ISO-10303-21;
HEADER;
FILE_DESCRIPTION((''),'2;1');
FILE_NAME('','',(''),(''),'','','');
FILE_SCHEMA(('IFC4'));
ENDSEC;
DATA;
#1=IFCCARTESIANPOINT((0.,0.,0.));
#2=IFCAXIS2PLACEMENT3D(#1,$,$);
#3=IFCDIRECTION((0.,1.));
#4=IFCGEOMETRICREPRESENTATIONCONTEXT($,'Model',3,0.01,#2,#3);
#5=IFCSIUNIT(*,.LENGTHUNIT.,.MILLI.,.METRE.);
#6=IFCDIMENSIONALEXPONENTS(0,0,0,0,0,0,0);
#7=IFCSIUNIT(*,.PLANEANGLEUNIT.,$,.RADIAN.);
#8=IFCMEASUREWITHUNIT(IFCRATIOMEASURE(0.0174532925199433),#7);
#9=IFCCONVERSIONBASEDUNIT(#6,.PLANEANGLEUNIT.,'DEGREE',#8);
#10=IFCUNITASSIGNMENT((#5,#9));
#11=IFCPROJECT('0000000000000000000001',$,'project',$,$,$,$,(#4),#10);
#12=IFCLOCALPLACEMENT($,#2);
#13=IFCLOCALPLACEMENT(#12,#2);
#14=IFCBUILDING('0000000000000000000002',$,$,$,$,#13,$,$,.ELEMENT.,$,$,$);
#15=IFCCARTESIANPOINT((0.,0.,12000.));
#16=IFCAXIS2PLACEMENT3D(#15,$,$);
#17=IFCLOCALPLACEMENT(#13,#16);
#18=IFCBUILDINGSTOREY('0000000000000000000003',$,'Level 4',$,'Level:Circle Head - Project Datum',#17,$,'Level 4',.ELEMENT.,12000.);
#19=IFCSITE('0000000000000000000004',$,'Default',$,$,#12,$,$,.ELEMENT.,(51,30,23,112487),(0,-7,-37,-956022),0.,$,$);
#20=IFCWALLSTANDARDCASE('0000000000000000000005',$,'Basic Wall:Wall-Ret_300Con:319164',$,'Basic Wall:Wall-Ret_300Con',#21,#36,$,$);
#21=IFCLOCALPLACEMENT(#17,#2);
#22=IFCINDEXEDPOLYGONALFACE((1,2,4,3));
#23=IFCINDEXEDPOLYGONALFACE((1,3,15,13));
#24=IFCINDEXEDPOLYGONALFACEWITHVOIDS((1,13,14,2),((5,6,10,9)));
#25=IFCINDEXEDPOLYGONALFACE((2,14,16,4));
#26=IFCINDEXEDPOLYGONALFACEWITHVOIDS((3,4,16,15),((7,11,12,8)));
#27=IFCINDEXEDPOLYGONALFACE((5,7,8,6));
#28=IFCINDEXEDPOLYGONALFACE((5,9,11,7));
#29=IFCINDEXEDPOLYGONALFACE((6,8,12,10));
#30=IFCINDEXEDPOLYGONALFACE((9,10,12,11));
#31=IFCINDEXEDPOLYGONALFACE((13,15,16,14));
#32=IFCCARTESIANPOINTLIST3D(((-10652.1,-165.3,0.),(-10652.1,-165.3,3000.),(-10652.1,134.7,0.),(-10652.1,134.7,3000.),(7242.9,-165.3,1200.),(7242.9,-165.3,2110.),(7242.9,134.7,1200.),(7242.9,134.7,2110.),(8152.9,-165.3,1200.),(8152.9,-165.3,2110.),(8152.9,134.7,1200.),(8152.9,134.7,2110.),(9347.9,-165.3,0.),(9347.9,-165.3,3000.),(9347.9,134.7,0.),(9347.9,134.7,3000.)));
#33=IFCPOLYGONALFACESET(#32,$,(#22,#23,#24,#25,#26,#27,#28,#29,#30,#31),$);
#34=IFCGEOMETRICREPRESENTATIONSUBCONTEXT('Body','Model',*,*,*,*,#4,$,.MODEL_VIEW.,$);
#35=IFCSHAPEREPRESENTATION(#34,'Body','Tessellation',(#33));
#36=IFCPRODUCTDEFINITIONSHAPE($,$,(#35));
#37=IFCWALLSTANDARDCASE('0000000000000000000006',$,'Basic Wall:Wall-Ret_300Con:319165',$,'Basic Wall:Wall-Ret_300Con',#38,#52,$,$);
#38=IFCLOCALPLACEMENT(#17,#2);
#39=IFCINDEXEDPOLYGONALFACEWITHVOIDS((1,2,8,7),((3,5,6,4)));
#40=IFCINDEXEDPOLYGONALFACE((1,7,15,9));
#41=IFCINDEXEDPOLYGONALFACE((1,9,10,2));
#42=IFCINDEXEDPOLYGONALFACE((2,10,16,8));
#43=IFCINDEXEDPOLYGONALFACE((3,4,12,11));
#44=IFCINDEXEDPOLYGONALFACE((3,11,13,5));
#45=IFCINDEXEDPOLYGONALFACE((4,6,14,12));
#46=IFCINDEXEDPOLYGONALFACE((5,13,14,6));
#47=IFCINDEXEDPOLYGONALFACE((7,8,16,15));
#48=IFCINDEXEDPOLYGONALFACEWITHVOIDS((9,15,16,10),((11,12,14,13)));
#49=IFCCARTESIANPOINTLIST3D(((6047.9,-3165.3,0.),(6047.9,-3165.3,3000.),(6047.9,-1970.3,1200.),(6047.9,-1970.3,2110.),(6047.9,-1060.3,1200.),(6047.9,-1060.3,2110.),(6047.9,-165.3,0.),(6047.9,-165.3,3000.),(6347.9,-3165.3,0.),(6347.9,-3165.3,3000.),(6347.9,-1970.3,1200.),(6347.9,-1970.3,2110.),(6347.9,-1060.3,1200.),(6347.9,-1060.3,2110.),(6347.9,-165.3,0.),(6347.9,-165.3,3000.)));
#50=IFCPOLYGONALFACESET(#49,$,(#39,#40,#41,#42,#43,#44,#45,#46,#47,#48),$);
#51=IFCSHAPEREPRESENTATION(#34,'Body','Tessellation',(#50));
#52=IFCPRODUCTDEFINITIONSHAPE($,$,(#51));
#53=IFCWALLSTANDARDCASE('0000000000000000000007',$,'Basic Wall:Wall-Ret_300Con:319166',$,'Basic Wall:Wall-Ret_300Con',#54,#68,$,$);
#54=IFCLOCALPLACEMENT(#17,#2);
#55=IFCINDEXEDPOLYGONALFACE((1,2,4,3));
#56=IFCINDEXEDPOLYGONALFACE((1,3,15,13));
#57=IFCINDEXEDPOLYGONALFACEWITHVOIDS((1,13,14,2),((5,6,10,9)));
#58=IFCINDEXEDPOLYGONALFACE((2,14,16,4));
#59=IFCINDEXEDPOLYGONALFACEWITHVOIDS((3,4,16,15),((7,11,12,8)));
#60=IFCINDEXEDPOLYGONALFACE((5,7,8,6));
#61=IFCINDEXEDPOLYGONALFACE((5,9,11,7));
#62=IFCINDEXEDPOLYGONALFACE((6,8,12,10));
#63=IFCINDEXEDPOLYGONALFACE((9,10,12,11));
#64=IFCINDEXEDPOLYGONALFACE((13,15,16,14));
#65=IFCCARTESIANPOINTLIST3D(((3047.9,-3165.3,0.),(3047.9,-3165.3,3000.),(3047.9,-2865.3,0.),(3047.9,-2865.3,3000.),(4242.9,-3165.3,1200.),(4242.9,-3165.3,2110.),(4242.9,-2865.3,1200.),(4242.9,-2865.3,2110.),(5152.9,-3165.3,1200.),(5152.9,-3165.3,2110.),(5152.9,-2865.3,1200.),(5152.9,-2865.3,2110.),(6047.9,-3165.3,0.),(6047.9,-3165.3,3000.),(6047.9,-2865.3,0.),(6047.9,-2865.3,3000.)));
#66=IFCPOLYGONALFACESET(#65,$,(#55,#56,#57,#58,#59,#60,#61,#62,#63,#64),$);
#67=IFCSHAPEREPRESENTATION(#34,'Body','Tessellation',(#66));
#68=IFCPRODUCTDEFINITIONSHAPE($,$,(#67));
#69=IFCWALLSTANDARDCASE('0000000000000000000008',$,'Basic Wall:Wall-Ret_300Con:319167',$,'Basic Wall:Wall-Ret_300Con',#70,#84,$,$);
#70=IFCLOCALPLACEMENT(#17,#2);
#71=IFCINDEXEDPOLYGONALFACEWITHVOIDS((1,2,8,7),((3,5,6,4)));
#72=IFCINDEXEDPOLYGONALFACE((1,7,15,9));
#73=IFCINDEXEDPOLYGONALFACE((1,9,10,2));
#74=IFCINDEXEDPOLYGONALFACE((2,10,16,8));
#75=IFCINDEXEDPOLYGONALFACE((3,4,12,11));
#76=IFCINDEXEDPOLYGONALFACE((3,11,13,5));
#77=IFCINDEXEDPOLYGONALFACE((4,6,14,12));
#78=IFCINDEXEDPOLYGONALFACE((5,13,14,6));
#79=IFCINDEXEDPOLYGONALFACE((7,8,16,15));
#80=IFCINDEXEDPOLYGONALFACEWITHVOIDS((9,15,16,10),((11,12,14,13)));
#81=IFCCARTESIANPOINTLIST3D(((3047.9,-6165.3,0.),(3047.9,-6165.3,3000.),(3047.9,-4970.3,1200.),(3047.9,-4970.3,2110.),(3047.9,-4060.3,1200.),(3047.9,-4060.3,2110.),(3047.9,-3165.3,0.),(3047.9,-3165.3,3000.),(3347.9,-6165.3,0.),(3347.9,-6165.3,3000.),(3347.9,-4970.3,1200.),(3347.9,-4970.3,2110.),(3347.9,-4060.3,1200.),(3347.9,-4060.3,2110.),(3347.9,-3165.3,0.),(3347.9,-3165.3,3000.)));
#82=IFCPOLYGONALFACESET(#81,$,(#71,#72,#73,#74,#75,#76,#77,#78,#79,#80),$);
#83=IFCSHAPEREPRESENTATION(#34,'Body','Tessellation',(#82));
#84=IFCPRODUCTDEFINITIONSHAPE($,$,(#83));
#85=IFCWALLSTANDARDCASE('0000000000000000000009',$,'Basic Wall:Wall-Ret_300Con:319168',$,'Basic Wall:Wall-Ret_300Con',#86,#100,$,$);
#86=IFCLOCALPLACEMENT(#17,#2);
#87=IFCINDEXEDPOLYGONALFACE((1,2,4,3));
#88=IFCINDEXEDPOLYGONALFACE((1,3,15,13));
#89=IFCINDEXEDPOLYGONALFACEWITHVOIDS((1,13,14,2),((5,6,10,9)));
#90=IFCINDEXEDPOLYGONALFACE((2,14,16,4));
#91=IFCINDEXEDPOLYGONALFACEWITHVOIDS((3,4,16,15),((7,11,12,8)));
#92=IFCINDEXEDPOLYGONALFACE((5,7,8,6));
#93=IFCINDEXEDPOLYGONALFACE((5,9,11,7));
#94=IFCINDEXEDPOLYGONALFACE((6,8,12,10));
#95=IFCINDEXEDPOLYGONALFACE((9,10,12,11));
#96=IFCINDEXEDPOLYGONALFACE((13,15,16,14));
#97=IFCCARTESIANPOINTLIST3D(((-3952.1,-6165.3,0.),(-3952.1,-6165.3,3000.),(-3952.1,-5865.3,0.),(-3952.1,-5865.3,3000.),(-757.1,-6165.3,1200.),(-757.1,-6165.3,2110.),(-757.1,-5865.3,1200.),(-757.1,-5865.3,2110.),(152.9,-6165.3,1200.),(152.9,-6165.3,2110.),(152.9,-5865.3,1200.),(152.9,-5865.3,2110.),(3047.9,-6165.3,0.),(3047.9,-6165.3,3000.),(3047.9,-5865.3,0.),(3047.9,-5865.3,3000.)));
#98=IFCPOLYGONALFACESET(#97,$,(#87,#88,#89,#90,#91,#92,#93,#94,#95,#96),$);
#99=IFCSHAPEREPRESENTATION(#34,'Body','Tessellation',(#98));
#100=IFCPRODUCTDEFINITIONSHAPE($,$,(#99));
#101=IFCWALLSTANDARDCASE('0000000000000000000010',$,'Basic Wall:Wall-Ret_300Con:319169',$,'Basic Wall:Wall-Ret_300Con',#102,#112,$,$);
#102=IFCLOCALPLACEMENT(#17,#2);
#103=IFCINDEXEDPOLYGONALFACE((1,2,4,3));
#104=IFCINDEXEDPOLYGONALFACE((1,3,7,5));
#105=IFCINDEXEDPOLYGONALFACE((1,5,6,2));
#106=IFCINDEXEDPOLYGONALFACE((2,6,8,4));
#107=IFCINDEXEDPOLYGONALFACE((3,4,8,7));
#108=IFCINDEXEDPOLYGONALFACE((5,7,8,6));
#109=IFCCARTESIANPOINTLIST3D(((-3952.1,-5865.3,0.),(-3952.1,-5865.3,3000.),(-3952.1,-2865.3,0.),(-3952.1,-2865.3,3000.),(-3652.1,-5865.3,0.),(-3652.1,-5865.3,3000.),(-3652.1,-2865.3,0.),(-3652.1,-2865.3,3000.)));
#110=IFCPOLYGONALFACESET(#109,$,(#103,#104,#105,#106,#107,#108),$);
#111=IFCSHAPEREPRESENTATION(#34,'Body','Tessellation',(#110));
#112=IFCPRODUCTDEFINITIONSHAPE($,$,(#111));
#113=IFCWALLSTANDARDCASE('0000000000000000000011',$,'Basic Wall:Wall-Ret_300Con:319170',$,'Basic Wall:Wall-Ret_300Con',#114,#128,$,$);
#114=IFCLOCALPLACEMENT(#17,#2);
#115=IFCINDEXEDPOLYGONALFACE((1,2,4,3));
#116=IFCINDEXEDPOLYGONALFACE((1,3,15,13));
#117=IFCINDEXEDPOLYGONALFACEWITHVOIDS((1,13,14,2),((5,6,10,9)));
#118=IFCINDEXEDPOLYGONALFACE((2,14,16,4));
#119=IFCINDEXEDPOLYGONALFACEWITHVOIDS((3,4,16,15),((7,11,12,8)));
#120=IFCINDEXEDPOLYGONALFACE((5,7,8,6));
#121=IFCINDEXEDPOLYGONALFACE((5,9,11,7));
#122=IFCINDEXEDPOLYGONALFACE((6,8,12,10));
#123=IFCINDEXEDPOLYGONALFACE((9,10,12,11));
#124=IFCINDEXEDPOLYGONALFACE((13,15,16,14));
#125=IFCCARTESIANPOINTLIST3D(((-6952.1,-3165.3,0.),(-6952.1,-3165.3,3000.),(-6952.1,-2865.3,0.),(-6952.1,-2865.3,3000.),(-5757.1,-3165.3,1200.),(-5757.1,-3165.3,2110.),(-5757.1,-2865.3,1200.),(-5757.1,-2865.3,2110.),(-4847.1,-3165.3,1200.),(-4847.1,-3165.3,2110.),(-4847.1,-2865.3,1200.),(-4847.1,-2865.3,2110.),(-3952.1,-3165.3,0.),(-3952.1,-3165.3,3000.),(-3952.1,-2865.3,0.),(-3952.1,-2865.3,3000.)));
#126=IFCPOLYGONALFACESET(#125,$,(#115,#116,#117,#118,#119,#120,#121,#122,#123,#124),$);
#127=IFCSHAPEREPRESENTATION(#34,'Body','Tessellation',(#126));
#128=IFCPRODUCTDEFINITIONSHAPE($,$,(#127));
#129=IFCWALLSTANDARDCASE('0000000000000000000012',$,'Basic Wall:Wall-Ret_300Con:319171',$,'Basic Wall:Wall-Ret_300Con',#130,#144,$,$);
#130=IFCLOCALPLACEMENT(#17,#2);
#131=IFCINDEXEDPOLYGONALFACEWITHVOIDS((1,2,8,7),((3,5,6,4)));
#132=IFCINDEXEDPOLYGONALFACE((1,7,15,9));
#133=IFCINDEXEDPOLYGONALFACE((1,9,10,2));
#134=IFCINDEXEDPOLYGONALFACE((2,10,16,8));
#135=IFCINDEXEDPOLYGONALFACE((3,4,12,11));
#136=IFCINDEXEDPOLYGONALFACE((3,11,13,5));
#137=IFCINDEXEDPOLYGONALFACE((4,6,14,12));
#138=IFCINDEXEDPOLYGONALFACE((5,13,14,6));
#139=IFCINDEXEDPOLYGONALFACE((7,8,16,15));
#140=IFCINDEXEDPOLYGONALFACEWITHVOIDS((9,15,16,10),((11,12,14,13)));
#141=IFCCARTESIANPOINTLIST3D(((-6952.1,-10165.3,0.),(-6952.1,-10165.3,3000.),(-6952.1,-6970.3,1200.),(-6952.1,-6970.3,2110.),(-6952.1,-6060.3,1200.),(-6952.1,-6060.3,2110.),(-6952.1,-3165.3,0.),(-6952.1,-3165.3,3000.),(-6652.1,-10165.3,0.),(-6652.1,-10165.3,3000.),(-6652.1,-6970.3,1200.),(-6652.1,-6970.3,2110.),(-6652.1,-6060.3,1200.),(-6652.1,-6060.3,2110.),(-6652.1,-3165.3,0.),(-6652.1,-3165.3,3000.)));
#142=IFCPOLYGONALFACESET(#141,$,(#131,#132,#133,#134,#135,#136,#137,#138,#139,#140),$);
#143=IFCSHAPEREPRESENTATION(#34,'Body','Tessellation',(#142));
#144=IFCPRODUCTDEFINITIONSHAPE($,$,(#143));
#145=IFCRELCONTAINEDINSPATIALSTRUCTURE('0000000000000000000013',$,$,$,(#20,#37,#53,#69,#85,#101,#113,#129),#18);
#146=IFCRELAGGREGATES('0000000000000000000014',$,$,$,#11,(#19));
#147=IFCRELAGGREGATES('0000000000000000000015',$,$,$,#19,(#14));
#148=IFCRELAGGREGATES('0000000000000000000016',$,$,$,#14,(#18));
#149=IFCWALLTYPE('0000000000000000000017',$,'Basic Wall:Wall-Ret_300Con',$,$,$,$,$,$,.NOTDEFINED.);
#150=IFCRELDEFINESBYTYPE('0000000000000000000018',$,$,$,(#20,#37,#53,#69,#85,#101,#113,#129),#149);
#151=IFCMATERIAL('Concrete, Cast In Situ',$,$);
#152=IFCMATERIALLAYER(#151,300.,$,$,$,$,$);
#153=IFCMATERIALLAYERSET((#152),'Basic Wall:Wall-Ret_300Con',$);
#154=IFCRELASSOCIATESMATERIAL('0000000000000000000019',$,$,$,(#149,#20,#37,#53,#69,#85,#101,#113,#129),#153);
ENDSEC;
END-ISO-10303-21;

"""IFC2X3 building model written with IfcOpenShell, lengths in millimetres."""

from ifc_helpers import new_model, entity, si_unit, converted_unit, direction, frame, frame_2d, origin, place, context, subcontext, project, spatial, rectangle, extrude, material, layer, layer_set, layer_usage, type_object, element, save


model = new_model("IFC2X3")

# Units and contexts
model_context = context("Model", 3, precision=0.01, world=origin(), true_north=direction((0.0, 1.0)))
body_context = subcontext(model_context, "Body", "Model", "MODEL_VIEW")
ifc_project = project(units=[si_unit("LENGTHUNIT", "METRE", prefix="MILLI"), converted_unit("PLANEANGLEUNIT", "DEGREE", entity("IfcRatioMeasure", 0.0174532925199433), si_unit("PLANEANGLEUNIT", "RADIAN"), dimensions=[0, 0, 0, 0, 0, 0, 0])], contexts=[model_context])

# Site, building, storey
site_placement = place(None, origin())
site = spatial("IfcSite", under=ifc_project, at=site_placement, Name="Default", CompositionType="ELEMENT", RefLatitude=(51, 30, 23, 112487), RefLongitude=(0, -7, -37, -956022), RefElevation=0.0)
building_placement = place(site_placement, origin())
building = spatial("IfcBuilding", under=site, at=building_placement, CompositionType="ELEMENT")
storey_placement = place(building_placement, frame((0.0, 0.0, 12000.0)))
storey = spatial("IfcBuildingStorey", under=building, at=storey_placement, Name="Level 4", ObjectType="Level:Circle Head - Project Datum", LongName="Level 4", CompositionType="ELEMENT", Elevation=12000.0)

# Walls, openings
ifc_material_1 = material(Name="Concrete, Cast In Situ")
ifc_layer_1 = layer(ifc_material_1, 300.0)
ifc_layer_set_1 = layer_set([ifc_layer_1], Name="Basic Wall:Wall-Ret_300Con")
ifc_layer_usage_1 = layer_usage(ifc_layer_set_1, "AXIS2", "NEGATIVE", 150.0)
wall_type = type_object("IfcWallType", Name="Basic Wall:Wall-Ret_300Con", PredefinedType="NOTDEFINED", material=ifc_layer_set_1)
wall_1_placement = place(storey_placement, frame((9347.9, -15.3, 0.0), z_axis=(0.0, 0.0, 1.0), x_axis=(-1.0, 0.0, 0.0)))
wall_1 = element("IfcWallStandardCase", 1, at=wall_1_placement, inside=storey, type_object=wall_type, material=ifc_layer_usage_1, Name="Basic Wall:Wall-Ret_300Con:319164", ObjectType="Basic Wall:Wall-Ret_300Con", context=body_context, shape_type="SweptSolid", body=[
    extrude(rectangle(XDim=20000.0, YDim=300.0, at=frame_2d((10000.0, 0.0), x_axis=(-1.0, 0.0))), origin(), (0.0, 0.0, 1.0), 3000.0),
])
opening_1_placement = place(wall_1_placement, frame((1195.0, -150.0, 1200.0)))
element("IfcOpeningElement", 2, at=opening_1_placement, cuts=wall_1, ObjectType="Opening", context=body_context, shape_type="SweptSolid", body=[
    extrude(rectangle(XDim=910.0, YDim=910.0, at=frame_2d((455.0, 455.0), x_axis=(-1.0, 0.0))), frame((0.0, 0.0, 0.0), z_axis=(0.0, 1.0, 0.0), x_axis=(0.0, 0.0, 1.0)), (0.0, 0.0, 1.0), 300.0),
])
ifc_layer_usage_2 = layer_usage(ifc_layer_set_1, "AXIS2", "NEGATIVE", 150.0)
wall_2_placement = place(storey_placement, frame((6197.9, -165.3, 0.0), z_axis=(0.0, 0.0, 1.0), x_axis=(0.0, -1.0, 0.0)))
wall_2 = element("IfcWallStandardCase", 3, at=wall_2_placement, inside=storey, type_object=wall_type, material=ifc_layer_usage_2, Name="Basic Wall:Wall-Ret_300Con:319165", ObjectType="Basic Wall:Wall-Ret_300Con", context=body_context, shape_type="SweptSolid", body=[
    extrude(rectangle(XDim=3000.0, YDim=300.0, at=frame_2d((1500.0, 0.0), x_axis=(-1.0, 0.0))), origin(), (0.0, 0.0, 1.0), 3000.0),
])
opening_2_placement = place(wall_2_placement, frame((895.0, -150.0, 1200.0)))
element("IfcOpeningElement", 4, at=opening_2_placement, cuts=wall_2, ObjectType="Opening", context=body_context, shape_type="SweptSolid", body=[
    extrude(rectangle(XDim=910.0, YDim=910.0, at=frame_2d((455.0, 455.0), x_axis=(-1.0, 0.0))), frame((0.0, 0.0, 0.0), z_axis=(0.0, 1.0, 0.0), x_axis=(0.0, 0.0, 1.0)), (0.0, 0.0, 1.0), 300.0),
])
ifc_layer_usage_3 = layer_usage(ifc_layer_set_1, "AXIS2", "NEGATIVE", 150.0)
wall_3_placement = place(storey_placement, frame((6047.9, -3015.3, 0.0), z_axis=(0.0, 0.0, 1.0), x_axis=(-1.0, 0.0, 0.0)))
wall_3 = element("IfcWallStandardCase", 5, at=wall_3_placement, inside=storey, type_object=wall_type, material=ifc_layer_usage_3, Name="Basic Wall:Wall-Ret_300Con:319166", ObjectType="Basic Wall:Wall-Ret_300Con", context=body_context, shape_type="SweptSolid", body=[
    extrude(rectangle(XDim=3000.0, YDim=300.0, at=frame_2d((1500.0, 0.0), x_axis=(-1.0, 0.0))), origin(), (0.0, 0.0, 1.0), 3000.0),
])
opening_3_placement = place(wall_3_placement, frame((895.0, -150.0, 1200.0)))
element("IfcOpeningElement", 6, at=opening_3_placement, cuts=wall_3, ObjectType="Opening", context=body_context, shape_type="SweptSolid", body=[
    extrude(rectangle(XDim=910.0, YDim=910.0, at=frame_2d((455.0, 455.0), x_axis=(-1.0, 0.0))), frame((0.0, 0.0, 0.0), z_axis=(0.0, 1.0, 0.0), x_axis=(0.0, 0.0, 1.0)), (0.0, 0.0, 1.0), 300.0),
])
ifc_layer_usage_4 = layer_usage(ifc_layer_set_1, "AXIS2", "NEGATIVE", 150.0)
wall_4_placement = place(storey_placement, frame((3197.9, -3165.3, 0.0), z_axis=(0.0, 0.0, 1.0), x_axis=(0.0, -1.0, 0.0)))
wall_4 = element("IfcWallStandardCase", 7, at=wall_4_placement, inside=storey, type_object=wall_type, material=ifc_layer_usage_4, Name="Basic Wall:Wall-Ret_300Con:319167", ObjectType="Basic Wall:Wall-Ret_300Con", context=body_context, shape_type="SweptSolid", body=[
    extrude(rectangle(XDim=3000.0, YDim=300.0, at=frame_2d((1500.0, 0.0), x_axis=(-1.0, 0.0))), origin(), (0.0, 0.0, 1.0), 3000.0),
])
opening_4_placement = place(wall_4_placement, frame((895.0, -150.0, 1200.0)))
element("IfcOpeningElement", 8, at=opening_4_placement, cuts=wall_4, ObjectType="Opening", context=body_context, shape_type="SweptSolid", body=[
    extrude(rectangle(XDim=910.0, YDim=910.0, at=frame_2d((455.0, 455.0), x_axis=(-1.0, 0.0))), frame((0.0, 0.0, 0.0), z_axis=(0.0, 1.0, 0.0), x_axis=(0.0, 0.0, 1.0)), (0.0, 0.0, 1.0), 300.0),
])
ifc_layer_usage_5 = layer_usage(ifc_layer_set_1, "AXIS2", "NEGATIVE", 150.0)
wall_5_placement = place(storey_placement, frame((3047.9, -6015.3, 0.0), z_axis=(0.0, 0.0, 1.0), x_axis=(-1.0, 0.0, 0.0)))
wall_5 = element("IfcWallStandardCase", 9, at=wall_5_placement, inside=storey, type_object=wall_type, material=ifc_layer_usage_5, Name="Basic Wall:Wall-Ret_300Con:319168", ObjectType="Basic Wall:Wall-Ret_300Con", context=body_context, shape_type="SweptSolid", body=[
    extrude(rectangle(XDim=7000.0, YDim=300.0, at=frame_2d((3500.0, 0.0), x_axis=(-1.0, 0.0))), origin(), (0.0, 0.0, 1.0), 3000.0),
])
opening_5_placement = place(wall_5_placement, frame((2895.0, -150.0, 1200.0)))
element("IfcOpeningElement", 10, at=opening_5_placement, cuts=wall_5, ObjectType="Opening", context=body_context, shape_type="SweptSolid", body=[
    extrude(rectangle(XDim=910.0, YDim=910.0, at=frame_2d((455.0, 455.0), x_axis=(-1.0, 0.0))), frame((0.0, 0.0, 0.0), z_axis=(0.0, 1.0, 0.0), x_axis=(0.0, 0.0, 1.0)), (0.0, 0.0, 1.0), 300.0),
])

# Wall
ifc_layer_usage_6 = layer_usage(ifc_layer_set_1, "AXIS2", "NEGATIVE", 150.0)
wall_6_placement = place(storey_placement, frame((-3802.1, -5865.3, 0.0), z_axis=(0.0, 0.0, 1.0), x_axis=(0.0, 1.0, 0.0)))
element("IfcWallStandardCase", 11, at=wall_6_placement, inside=storey, type_object=wall_type, material=ifc_layer_usage_6, Name="Basic Wall:Wall-Ret_300Con:319169", ObjectType="Basic Wall:Wall-Ret_300Con", context=body_context, shape_type="SweptSolid", body=[
    extrude(rectangle(XDim=3000.0, YDim=300.0, at=frame_2d((1500.0, 0.0), x_axis=(-1.0, 0.0))), origin(), (0.0, 0.0, 1.0), 3000.0),
])

# Walls, openings
ifc_layer_usage_7 = layer_usage(ifc_layer_set_1, "AXIS2", "NEGATIVE", 150.0)
wall_7_placement = place(storey_placement, frame((-3952.1, -3015.3, 0.0), z_axis=(0.0, 0.0, 1.0), x_axis=(-1.0, 0.0, 0.0)))
wall_7 = element("IfcWallStandardCase", 12, at=wall_7_placement, inside=storey, type_object=wall_type, material=ifc_layer_usage_7, Name="Basic Wall:Wall-Ret_300Con:319170", ObjectType="Basic Wall:Wall-Ret_300Con", context=body_context, shape_type="SweptSolid", body=[
    extrude(rectangle(XDim=3000.0, YDim=300.0, at=frame_2d((1500.0, 0.0), x_axis=(-1.0, 0.0))), origin(), (0.0, 0.0, 1.0), 3000.0),
])
opening_6_placement = place(wall_7_placement, frame((895.0, -150.0, 1200.0)))
element("IfcOpeningElement", 13, at=opening_6_placement, cuts=wall_7, ObjectType="Opening", context=body_context, shape_type="SweptSolid", body=[
    extrude(rectangle(XDim=910.0, YDim=910.0, at=frame_2d((455.0, 455.0), x_axis=(-1.0, 0.0))), frame((0.0, 0.0, 0.0), z_axis=(0.0, 1.0, 0.0), x_axis=(0.0, 0.0, 1.0)), (0.0, 0.0, 1.0), 300.0),
])
ifc_layer_usage_8 = layer_usage(ifc_layer_set_1, "AXIS2", "NEGATIVE", 150.0)
wall_8_placement = place(storey_placement, frame((-6802.1, -3165.3, 0.0), z_axis=(0.0, 0.0, 1.0), x_axis=(0.0, -1.0, 0.0)))
wall_8 = element("IfcWallStandardCase", 14, at=wall_8_placement, inside=storey, type_object=wall_type, material=ifc_layer_usage_8, Name="Basic Wall:Wall-Ret_300Con:319171", ObjectType="Basic Wall:Wall-Ret_300Con", context=body_context, shape_type="SweptSolid", body=[
    extrude(rectangle(XDim=7000.0, YDim=300.0, at=frame_2d((3500.0, 0.0), x_axis=(-1.0, 0.0))), origin(), (0.0, 0.0, 1.0), 3000.0),
])
opening_7_placement = place(wall_8_placement, frame((2895.0, -150.0, 1200.0)))
element("IfcOpeningElement", 15, at=opening_7_placement, cuts=wall_8, ObjectType="Opening", context=body_context, shape_type="SweptSolid", body=[
    extrude(rectangle(XDim=910.0, YDim=910.0, at=frame_2d((455.0, 455.0), x_axis=(-1.0, 0.0))), frame((0.0, 0.0, 0.0), z_axis=(0.0, 1.0, 0.0), x_axis=(0.0, 0.0, 1.0)), (0.0, 0.0, 1.0), 300.0),
])

save(model, "model.ifc")
